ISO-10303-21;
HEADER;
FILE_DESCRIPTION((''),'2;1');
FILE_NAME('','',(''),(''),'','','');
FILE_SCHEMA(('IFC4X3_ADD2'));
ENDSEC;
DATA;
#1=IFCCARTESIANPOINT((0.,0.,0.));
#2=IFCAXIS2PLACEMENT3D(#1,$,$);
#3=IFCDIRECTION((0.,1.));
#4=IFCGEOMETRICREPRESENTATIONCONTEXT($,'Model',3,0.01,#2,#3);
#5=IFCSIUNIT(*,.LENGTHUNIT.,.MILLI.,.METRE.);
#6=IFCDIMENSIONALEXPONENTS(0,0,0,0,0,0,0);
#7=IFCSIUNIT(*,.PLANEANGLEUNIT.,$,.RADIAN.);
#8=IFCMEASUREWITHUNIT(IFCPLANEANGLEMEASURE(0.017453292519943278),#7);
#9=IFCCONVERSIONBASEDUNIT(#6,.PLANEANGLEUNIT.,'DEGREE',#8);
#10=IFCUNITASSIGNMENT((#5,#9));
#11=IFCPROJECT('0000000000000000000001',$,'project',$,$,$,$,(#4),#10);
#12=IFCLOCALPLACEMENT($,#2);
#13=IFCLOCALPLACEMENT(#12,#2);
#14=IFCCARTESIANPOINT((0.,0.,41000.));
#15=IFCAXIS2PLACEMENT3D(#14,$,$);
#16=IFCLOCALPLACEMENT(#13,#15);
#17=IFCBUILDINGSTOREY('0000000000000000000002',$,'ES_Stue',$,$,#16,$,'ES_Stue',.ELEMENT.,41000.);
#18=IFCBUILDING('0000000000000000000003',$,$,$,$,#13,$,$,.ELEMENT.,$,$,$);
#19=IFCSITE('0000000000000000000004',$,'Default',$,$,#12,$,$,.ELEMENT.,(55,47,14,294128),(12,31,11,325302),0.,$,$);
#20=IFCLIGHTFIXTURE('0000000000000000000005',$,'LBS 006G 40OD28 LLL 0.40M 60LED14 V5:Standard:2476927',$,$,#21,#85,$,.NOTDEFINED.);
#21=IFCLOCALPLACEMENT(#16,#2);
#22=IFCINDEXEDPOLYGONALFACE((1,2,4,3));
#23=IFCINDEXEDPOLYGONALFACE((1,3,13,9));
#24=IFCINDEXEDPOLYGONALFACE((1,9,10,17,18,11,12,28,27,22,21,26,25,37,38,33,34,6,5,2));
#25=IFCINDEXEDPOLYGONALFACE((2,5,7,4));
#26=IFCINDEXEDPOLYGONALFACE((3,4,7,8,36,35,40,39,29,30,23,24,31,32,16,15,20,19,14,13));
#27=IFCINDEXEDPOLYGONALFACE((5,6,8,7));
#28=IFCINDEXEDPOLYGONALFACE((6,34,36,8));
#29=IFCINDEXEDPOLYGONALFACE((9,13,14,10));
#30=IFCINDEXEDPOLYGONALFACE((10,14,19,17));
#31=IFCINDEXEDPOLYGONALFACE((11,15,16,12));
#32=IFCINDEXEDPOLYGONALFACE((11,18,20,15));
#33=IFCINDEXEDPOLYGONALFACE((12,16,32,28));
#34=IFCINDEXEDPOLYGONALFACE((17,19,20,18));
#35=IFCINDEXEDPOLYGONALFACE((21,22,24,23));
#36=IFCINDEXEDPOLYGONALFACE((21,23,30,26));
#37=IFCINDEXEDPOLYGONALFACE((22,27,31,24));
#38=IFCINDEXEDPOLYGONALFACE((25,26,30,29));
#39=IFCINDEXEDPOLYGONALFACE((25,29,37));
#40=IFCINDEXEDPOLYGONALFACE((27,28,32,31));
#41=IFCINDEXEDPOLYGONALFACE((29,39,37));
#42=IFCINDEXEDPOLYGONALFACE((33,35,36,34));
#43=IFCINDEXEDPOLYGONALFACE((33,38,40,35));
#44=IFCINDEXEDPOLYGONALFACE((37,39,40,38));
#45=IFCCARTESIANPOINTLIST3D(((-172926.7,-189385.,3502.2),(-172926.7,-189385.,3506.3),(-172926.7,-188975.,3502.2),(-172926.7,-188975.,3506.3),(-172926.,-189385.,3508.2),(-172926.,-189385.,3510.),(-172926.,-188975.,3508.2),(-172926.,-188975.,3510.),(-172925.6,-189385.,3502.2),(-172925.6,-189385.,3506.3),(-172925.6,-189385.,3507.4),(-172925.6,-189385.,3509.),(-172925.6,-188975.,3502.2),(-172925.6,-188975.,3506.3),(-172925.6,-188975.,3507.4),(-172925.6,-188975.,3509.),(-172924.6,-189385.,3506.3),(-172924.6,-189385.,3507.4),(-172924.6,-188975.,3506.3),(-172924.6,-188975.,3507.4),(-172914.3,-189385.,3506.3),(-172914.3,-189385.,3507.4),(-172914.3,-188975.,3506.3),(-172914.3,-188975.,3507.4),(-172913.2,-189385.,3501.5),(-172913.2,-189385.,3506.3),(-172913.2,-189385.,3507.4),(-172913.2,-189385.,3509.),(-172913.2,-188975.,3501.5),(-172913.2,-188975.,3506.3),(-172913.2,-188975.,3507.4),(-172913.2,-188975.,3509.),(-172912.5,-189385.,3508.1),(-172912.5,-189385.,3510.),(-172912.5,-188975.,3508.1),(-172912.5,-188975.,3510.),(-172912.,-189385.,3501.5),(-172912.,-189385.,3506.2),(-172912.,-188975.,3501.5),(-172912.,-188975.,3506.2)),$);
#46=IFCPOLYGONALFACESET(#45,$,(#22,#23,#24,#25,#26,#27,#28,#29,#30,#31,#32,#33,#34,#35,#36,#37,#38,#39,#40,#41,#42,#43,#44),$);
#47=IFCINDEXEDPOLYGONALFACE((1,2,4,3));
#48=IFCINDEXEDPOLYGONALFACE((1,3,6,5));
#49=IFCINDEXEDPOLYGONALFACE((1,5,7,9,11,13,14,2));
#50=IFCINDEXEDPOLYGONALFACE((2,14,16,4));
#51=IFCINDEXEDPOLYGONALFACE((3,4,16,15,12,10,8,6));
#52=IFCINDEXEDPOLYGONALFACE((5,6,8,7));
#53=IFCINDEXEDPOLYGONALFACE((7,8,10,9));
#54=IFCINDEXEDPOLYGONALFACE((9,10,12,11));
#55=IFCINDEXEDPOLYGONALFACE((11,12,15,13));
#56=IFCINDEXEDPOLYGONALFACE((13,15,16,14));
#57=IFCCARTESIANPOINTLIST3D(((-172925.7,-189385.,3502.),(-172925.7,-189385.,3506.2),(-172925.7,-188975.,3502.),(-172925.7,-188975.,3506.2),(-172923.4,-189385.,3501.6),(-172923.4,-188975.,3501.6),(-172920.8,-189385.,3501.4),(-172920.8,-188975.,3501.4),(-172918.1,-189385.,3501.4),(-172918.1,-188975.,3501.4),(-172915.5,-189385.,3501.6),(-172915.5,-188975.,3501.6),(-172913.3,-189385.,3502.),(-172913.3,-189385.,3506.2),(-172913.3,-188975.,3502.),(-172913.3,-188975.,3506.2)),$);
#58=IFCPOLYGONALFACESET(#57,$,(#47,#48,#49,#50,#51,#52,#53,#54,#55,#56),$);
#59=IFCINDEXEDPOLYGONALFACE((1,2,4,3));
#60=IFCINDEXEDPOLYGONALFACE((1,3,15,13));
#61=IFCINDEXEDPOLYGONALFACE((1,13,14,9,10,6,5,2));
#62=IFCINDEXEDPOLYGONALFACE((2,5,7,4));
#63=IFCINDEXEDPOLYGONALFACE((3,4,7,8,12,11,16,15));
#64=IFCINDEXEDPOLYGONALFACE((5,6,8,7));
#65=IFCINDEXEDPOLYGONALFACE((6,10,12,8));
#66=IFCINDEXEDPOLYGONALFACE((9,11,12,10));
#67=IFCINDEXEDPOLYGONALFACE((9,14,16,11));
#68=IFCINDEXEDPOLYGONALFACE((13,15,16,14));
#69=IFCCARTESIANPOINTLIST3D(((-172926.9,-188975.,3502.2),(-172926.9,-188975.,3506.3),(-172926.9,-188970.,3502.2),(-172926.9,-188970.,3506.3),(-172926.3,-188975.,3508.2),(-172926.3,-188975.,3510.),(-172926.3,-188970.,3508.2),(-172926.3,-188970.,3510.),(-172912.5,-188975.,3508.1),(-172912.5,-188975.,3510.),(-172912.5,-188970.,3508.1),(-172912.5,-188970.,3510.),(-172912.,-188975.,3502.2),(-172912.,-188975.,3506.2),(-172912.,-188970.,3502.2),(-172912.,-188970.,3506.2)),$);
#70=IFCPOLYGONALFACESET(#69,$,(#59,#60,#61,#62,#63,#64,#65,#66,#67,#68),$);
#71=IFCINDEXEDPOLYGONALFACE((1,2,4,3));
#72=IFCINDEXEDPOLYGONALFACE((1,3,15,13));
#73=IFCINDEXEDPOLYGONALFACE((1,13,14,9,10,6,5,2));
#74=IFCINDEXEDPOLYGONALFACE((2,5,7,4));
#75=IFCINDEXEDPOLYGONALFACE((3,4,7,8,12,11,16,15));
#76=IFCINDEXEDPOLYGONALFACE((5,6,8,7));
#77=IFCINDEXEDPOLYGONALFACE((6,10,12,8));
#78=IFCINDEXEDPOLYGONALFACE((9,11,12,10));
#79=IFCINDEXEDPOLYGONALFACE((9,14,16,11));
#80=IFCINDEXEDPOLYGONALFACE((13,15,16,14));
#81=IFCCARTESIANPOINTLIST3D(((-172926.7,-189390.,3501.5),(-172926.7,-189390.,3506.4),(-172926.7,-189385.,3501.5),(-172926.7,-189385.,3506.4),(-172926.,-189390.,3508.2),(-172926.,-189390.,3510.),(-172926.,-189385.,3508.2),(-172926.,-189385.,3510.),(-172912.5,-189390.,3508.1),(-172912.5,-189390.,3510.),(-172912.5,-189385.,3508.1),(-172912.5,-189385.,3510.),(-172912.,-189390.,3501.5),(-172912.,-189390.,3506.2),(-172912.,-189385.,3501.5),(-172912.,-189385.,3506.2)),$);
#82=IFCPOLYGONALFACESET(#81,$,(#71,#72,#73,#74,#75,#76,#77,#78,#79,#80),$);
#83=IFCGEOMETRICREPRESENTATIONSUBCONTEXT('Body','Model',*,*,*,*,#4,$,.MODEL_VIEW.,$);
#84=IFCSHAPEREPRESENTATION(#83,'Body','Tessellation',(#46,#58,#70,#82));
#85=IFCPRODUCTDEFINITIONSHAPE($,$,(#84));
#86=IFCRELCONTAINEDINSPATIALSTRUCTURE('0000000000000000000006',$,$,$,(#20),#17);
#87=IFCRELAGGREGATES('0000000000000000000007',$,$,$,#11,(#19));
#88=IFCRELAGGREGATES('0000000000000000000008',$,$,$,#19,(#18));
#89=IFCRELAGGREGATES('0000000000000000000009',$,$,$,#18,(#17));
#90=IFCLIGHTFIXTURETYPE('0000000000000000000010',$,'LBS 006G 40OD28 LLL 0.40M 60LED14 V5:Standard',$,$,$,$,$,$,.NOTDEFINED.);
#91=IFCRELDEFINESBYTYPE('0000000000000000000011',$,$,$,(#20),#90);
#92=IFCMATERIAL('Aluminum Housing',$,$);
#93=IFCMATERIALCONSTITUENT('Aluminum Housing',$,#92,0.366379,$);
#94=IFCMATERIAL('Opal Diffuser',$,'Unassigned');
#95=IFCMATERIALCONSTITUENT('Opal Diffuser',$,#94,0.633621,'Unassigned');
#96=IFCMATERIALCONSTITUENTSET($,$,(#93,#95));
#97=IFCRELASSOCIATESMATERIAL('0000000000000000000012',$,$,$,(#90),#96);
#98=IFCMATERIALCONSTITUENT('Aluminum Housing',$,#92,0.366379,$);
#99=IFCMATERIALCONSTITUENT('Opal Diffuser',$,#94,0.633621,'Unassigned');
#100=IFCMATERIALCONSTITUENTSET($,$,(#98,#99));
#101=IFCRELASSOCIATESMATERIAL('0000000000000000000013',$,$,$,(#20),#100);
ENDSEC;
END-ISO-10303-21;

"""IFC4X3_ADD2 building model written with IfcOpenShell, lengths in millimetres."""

from ifc_helpers import new_model, entity, si_unit, converted_unit, direction, frame, origin, place, context, subcontext, project, spatial, polyline, outline, extrude, source, transform, mapped, material, constituent, constituent_set, type_object, type_shapes, element, save


model = new_model("IFC4X3_ADD2")

# Units and contexts
model_context = context("Model", 3, precision=0.01, world=origin(), true_north=direction((0.0, 1.0)))
body_context = subcontext(model_context, "Body", "Model", "MODEL_VIEW")
ifc_project = project(units=[si_unit("LENGTHUNIT", "METRE", prefix="MILLI"), converted_unit("PLANEANGLEUNIT", "DEGREE", entity("IfcPlaneAngleMeasure", 0.017453292519943278), si_unit("PLANEANGLEUNIT", "RADIAN"), dimensions=[0, 0, 0, 0, 0, 0, 0])], contexts=[model_context])

# Site, building, storey
site_placement = place(None, origin())
site = spatial("IfcSite", under=ifc_project, at=site_placement, Name="Default", CompositionType="ELEMENT", RefLatitude=(55, 47, 14, 294128), RefLongitude=(12, 31, 11, 325302), RefElevation=0.0)
building_placement = place(site_placement, origin())
building = spatial("IfcBuilding", under=site, at=building_placement, CompositionType="ELEMENT")
storey_placement = place(building_placement, frame((0.0, 0.0, 41000.0)))
storey = spatial("IfcBuildingStorey", under=building, at=storey_placement, Name="ES_Stue", LongName="ES_Stue", CompositionType="ELEMENT", Elevation=41000.0)

# Light fixture
ifc_material_1 = material(Name="Aluminum Housing")
ifc_constituent_1 = constituent(ifc_material_1, Name="Aluminum Housing", fraction=0.366379)
ifc_material_2 = material(Name="Opal Diffuser", Category="Unassigned")
ifc_constituent_2 = constituent(ifc_material_2, Name="Opal Diffuser", Category="Unassigned", fraction=0.633621)
ifc_constituent_set_1 = constituent_set(constituents=[ifc_constituent_1, ifc_constituent_2])
ifc_constituent_3 = constituent(ifc_material_1, Name="Aluminum Housing", fraction=0.366379)
ifc_constituent_4 = constituent(ifc_material_2, Name="Opal Diffuser", Category="Unassigned", fraction=0.633621)
ifc_constituent_set_2 = constituent_set(constituents=[ifc_constituent_3, ifc_constituent_4])
light_fixture_type = type_object("IfcLightFixtureType", Name="LBS 006G 40OD28 LLL 0.40M 60LED14 V5:Standard", PredefinedType="NOTDEFINED", material=ifc_constituent_set_2)
shared_shape_1 = source(origin(), body_context, "Body", "SweptSolid", [
    extrude(outline(polyline([(-5.0, -6.1), (-5.0, -7.4), (-0.3, -7.4), (1.7, -6.8), (3.5, -6.8), (3.5, 6.7), (1.8, 6.7), (-0.1, 7.3), (-4.2, 7.3), (-4.2, 6.2), (-0.1, 6.2), (-0.1, 5.2), (0.9, 5.2), (0.9, 6.2), (2.5, 6.2), (2.5, -6.1), (0.9, -6.1), (0.9, -5.1), (-0.1, -5.1), (-0.1, -6.1), (-5.0, -6.1)])), frame((-205.0, 0.1, 3.5), z_axis=(-1.0, 0.0, 0.0), x_axis=(0.0, 0.0, -1.0)), (0.0, 0.0, -1.0), 410.0),
    extrude(outline(polyline([(-0.8, -6.2), (3.4, -6.2), (3.4, 6.2), (-0.8, 6.2), (-1.2, 3.9), (-1.4, 1.4), (-1.4, -1.3), (-1.2, -3.9), (-0.8, -6.2)])), frame((-205.0, 0.0, 7.2), z_axis=(1.0, 0.0, 0.0), x_axis=(0.0, 0.0, -1.0)), (0.0, 0.0, 1.0), 410.0),
    extrude(outline(polyline([(-4.4, -7.5), (-0.3, -7.5), (1.5, -6.8), (3.3, -6.8), (3.3, 6.9), (1.5, 6.9), (-0.5, 7.4), (-4.4, 7.4), (-4.4, -7.5)])), frame((205.0, 0.0, 3.3), z_axis=(1.0, 0.0, 0.0), x_axis=(0.0, 0.0, -1.0)), (0.0, 0.0, 1.0), 5.0),
    extrude(outline(polyline([(-5.0, -7.4), (-0.1, -7.4), (1.7, -6.7), (3.5, -6.7), (3.5, 6.8), (1.6, 6.8), (-0.3, 7.3), (-5.0, 7.3), (-5.0, -7.4)])), frame((-210.0, 0.2, 3.5), z_axis=(1.0, 0.0, 0.0), x_axis=(0.0, 0.0, -1.0)), (0.0, 0.0, 1.0), 5.0),
])
type_shapes(light_fixture_type, [shared_shape_1])
light_fixture_placement = place(storey_placement, frame((-172919.5, -189180.0, 3510.0), z_axis=(0.0, 0.0, -1.0), x_axis=(0.0, 1.0, 0.0)))
element("IfcLightFixture", 1, at=light_fixture_placement, inside=storey, type_object=light_fixture_type, material=ifc_constituent_set_1, Name="LBS 006G 40OD28 LLL 0.40M 60LED14 V5:Standard:2476927", PredefinedType="NOTDEFINED", context=body_context, shape_type="MappedRepresentation", body=[
    mapped(shared_shape_1, transform((0.0, 0.0, 0.0), scale=1.0)),
])

save(model, "model.ifc")
